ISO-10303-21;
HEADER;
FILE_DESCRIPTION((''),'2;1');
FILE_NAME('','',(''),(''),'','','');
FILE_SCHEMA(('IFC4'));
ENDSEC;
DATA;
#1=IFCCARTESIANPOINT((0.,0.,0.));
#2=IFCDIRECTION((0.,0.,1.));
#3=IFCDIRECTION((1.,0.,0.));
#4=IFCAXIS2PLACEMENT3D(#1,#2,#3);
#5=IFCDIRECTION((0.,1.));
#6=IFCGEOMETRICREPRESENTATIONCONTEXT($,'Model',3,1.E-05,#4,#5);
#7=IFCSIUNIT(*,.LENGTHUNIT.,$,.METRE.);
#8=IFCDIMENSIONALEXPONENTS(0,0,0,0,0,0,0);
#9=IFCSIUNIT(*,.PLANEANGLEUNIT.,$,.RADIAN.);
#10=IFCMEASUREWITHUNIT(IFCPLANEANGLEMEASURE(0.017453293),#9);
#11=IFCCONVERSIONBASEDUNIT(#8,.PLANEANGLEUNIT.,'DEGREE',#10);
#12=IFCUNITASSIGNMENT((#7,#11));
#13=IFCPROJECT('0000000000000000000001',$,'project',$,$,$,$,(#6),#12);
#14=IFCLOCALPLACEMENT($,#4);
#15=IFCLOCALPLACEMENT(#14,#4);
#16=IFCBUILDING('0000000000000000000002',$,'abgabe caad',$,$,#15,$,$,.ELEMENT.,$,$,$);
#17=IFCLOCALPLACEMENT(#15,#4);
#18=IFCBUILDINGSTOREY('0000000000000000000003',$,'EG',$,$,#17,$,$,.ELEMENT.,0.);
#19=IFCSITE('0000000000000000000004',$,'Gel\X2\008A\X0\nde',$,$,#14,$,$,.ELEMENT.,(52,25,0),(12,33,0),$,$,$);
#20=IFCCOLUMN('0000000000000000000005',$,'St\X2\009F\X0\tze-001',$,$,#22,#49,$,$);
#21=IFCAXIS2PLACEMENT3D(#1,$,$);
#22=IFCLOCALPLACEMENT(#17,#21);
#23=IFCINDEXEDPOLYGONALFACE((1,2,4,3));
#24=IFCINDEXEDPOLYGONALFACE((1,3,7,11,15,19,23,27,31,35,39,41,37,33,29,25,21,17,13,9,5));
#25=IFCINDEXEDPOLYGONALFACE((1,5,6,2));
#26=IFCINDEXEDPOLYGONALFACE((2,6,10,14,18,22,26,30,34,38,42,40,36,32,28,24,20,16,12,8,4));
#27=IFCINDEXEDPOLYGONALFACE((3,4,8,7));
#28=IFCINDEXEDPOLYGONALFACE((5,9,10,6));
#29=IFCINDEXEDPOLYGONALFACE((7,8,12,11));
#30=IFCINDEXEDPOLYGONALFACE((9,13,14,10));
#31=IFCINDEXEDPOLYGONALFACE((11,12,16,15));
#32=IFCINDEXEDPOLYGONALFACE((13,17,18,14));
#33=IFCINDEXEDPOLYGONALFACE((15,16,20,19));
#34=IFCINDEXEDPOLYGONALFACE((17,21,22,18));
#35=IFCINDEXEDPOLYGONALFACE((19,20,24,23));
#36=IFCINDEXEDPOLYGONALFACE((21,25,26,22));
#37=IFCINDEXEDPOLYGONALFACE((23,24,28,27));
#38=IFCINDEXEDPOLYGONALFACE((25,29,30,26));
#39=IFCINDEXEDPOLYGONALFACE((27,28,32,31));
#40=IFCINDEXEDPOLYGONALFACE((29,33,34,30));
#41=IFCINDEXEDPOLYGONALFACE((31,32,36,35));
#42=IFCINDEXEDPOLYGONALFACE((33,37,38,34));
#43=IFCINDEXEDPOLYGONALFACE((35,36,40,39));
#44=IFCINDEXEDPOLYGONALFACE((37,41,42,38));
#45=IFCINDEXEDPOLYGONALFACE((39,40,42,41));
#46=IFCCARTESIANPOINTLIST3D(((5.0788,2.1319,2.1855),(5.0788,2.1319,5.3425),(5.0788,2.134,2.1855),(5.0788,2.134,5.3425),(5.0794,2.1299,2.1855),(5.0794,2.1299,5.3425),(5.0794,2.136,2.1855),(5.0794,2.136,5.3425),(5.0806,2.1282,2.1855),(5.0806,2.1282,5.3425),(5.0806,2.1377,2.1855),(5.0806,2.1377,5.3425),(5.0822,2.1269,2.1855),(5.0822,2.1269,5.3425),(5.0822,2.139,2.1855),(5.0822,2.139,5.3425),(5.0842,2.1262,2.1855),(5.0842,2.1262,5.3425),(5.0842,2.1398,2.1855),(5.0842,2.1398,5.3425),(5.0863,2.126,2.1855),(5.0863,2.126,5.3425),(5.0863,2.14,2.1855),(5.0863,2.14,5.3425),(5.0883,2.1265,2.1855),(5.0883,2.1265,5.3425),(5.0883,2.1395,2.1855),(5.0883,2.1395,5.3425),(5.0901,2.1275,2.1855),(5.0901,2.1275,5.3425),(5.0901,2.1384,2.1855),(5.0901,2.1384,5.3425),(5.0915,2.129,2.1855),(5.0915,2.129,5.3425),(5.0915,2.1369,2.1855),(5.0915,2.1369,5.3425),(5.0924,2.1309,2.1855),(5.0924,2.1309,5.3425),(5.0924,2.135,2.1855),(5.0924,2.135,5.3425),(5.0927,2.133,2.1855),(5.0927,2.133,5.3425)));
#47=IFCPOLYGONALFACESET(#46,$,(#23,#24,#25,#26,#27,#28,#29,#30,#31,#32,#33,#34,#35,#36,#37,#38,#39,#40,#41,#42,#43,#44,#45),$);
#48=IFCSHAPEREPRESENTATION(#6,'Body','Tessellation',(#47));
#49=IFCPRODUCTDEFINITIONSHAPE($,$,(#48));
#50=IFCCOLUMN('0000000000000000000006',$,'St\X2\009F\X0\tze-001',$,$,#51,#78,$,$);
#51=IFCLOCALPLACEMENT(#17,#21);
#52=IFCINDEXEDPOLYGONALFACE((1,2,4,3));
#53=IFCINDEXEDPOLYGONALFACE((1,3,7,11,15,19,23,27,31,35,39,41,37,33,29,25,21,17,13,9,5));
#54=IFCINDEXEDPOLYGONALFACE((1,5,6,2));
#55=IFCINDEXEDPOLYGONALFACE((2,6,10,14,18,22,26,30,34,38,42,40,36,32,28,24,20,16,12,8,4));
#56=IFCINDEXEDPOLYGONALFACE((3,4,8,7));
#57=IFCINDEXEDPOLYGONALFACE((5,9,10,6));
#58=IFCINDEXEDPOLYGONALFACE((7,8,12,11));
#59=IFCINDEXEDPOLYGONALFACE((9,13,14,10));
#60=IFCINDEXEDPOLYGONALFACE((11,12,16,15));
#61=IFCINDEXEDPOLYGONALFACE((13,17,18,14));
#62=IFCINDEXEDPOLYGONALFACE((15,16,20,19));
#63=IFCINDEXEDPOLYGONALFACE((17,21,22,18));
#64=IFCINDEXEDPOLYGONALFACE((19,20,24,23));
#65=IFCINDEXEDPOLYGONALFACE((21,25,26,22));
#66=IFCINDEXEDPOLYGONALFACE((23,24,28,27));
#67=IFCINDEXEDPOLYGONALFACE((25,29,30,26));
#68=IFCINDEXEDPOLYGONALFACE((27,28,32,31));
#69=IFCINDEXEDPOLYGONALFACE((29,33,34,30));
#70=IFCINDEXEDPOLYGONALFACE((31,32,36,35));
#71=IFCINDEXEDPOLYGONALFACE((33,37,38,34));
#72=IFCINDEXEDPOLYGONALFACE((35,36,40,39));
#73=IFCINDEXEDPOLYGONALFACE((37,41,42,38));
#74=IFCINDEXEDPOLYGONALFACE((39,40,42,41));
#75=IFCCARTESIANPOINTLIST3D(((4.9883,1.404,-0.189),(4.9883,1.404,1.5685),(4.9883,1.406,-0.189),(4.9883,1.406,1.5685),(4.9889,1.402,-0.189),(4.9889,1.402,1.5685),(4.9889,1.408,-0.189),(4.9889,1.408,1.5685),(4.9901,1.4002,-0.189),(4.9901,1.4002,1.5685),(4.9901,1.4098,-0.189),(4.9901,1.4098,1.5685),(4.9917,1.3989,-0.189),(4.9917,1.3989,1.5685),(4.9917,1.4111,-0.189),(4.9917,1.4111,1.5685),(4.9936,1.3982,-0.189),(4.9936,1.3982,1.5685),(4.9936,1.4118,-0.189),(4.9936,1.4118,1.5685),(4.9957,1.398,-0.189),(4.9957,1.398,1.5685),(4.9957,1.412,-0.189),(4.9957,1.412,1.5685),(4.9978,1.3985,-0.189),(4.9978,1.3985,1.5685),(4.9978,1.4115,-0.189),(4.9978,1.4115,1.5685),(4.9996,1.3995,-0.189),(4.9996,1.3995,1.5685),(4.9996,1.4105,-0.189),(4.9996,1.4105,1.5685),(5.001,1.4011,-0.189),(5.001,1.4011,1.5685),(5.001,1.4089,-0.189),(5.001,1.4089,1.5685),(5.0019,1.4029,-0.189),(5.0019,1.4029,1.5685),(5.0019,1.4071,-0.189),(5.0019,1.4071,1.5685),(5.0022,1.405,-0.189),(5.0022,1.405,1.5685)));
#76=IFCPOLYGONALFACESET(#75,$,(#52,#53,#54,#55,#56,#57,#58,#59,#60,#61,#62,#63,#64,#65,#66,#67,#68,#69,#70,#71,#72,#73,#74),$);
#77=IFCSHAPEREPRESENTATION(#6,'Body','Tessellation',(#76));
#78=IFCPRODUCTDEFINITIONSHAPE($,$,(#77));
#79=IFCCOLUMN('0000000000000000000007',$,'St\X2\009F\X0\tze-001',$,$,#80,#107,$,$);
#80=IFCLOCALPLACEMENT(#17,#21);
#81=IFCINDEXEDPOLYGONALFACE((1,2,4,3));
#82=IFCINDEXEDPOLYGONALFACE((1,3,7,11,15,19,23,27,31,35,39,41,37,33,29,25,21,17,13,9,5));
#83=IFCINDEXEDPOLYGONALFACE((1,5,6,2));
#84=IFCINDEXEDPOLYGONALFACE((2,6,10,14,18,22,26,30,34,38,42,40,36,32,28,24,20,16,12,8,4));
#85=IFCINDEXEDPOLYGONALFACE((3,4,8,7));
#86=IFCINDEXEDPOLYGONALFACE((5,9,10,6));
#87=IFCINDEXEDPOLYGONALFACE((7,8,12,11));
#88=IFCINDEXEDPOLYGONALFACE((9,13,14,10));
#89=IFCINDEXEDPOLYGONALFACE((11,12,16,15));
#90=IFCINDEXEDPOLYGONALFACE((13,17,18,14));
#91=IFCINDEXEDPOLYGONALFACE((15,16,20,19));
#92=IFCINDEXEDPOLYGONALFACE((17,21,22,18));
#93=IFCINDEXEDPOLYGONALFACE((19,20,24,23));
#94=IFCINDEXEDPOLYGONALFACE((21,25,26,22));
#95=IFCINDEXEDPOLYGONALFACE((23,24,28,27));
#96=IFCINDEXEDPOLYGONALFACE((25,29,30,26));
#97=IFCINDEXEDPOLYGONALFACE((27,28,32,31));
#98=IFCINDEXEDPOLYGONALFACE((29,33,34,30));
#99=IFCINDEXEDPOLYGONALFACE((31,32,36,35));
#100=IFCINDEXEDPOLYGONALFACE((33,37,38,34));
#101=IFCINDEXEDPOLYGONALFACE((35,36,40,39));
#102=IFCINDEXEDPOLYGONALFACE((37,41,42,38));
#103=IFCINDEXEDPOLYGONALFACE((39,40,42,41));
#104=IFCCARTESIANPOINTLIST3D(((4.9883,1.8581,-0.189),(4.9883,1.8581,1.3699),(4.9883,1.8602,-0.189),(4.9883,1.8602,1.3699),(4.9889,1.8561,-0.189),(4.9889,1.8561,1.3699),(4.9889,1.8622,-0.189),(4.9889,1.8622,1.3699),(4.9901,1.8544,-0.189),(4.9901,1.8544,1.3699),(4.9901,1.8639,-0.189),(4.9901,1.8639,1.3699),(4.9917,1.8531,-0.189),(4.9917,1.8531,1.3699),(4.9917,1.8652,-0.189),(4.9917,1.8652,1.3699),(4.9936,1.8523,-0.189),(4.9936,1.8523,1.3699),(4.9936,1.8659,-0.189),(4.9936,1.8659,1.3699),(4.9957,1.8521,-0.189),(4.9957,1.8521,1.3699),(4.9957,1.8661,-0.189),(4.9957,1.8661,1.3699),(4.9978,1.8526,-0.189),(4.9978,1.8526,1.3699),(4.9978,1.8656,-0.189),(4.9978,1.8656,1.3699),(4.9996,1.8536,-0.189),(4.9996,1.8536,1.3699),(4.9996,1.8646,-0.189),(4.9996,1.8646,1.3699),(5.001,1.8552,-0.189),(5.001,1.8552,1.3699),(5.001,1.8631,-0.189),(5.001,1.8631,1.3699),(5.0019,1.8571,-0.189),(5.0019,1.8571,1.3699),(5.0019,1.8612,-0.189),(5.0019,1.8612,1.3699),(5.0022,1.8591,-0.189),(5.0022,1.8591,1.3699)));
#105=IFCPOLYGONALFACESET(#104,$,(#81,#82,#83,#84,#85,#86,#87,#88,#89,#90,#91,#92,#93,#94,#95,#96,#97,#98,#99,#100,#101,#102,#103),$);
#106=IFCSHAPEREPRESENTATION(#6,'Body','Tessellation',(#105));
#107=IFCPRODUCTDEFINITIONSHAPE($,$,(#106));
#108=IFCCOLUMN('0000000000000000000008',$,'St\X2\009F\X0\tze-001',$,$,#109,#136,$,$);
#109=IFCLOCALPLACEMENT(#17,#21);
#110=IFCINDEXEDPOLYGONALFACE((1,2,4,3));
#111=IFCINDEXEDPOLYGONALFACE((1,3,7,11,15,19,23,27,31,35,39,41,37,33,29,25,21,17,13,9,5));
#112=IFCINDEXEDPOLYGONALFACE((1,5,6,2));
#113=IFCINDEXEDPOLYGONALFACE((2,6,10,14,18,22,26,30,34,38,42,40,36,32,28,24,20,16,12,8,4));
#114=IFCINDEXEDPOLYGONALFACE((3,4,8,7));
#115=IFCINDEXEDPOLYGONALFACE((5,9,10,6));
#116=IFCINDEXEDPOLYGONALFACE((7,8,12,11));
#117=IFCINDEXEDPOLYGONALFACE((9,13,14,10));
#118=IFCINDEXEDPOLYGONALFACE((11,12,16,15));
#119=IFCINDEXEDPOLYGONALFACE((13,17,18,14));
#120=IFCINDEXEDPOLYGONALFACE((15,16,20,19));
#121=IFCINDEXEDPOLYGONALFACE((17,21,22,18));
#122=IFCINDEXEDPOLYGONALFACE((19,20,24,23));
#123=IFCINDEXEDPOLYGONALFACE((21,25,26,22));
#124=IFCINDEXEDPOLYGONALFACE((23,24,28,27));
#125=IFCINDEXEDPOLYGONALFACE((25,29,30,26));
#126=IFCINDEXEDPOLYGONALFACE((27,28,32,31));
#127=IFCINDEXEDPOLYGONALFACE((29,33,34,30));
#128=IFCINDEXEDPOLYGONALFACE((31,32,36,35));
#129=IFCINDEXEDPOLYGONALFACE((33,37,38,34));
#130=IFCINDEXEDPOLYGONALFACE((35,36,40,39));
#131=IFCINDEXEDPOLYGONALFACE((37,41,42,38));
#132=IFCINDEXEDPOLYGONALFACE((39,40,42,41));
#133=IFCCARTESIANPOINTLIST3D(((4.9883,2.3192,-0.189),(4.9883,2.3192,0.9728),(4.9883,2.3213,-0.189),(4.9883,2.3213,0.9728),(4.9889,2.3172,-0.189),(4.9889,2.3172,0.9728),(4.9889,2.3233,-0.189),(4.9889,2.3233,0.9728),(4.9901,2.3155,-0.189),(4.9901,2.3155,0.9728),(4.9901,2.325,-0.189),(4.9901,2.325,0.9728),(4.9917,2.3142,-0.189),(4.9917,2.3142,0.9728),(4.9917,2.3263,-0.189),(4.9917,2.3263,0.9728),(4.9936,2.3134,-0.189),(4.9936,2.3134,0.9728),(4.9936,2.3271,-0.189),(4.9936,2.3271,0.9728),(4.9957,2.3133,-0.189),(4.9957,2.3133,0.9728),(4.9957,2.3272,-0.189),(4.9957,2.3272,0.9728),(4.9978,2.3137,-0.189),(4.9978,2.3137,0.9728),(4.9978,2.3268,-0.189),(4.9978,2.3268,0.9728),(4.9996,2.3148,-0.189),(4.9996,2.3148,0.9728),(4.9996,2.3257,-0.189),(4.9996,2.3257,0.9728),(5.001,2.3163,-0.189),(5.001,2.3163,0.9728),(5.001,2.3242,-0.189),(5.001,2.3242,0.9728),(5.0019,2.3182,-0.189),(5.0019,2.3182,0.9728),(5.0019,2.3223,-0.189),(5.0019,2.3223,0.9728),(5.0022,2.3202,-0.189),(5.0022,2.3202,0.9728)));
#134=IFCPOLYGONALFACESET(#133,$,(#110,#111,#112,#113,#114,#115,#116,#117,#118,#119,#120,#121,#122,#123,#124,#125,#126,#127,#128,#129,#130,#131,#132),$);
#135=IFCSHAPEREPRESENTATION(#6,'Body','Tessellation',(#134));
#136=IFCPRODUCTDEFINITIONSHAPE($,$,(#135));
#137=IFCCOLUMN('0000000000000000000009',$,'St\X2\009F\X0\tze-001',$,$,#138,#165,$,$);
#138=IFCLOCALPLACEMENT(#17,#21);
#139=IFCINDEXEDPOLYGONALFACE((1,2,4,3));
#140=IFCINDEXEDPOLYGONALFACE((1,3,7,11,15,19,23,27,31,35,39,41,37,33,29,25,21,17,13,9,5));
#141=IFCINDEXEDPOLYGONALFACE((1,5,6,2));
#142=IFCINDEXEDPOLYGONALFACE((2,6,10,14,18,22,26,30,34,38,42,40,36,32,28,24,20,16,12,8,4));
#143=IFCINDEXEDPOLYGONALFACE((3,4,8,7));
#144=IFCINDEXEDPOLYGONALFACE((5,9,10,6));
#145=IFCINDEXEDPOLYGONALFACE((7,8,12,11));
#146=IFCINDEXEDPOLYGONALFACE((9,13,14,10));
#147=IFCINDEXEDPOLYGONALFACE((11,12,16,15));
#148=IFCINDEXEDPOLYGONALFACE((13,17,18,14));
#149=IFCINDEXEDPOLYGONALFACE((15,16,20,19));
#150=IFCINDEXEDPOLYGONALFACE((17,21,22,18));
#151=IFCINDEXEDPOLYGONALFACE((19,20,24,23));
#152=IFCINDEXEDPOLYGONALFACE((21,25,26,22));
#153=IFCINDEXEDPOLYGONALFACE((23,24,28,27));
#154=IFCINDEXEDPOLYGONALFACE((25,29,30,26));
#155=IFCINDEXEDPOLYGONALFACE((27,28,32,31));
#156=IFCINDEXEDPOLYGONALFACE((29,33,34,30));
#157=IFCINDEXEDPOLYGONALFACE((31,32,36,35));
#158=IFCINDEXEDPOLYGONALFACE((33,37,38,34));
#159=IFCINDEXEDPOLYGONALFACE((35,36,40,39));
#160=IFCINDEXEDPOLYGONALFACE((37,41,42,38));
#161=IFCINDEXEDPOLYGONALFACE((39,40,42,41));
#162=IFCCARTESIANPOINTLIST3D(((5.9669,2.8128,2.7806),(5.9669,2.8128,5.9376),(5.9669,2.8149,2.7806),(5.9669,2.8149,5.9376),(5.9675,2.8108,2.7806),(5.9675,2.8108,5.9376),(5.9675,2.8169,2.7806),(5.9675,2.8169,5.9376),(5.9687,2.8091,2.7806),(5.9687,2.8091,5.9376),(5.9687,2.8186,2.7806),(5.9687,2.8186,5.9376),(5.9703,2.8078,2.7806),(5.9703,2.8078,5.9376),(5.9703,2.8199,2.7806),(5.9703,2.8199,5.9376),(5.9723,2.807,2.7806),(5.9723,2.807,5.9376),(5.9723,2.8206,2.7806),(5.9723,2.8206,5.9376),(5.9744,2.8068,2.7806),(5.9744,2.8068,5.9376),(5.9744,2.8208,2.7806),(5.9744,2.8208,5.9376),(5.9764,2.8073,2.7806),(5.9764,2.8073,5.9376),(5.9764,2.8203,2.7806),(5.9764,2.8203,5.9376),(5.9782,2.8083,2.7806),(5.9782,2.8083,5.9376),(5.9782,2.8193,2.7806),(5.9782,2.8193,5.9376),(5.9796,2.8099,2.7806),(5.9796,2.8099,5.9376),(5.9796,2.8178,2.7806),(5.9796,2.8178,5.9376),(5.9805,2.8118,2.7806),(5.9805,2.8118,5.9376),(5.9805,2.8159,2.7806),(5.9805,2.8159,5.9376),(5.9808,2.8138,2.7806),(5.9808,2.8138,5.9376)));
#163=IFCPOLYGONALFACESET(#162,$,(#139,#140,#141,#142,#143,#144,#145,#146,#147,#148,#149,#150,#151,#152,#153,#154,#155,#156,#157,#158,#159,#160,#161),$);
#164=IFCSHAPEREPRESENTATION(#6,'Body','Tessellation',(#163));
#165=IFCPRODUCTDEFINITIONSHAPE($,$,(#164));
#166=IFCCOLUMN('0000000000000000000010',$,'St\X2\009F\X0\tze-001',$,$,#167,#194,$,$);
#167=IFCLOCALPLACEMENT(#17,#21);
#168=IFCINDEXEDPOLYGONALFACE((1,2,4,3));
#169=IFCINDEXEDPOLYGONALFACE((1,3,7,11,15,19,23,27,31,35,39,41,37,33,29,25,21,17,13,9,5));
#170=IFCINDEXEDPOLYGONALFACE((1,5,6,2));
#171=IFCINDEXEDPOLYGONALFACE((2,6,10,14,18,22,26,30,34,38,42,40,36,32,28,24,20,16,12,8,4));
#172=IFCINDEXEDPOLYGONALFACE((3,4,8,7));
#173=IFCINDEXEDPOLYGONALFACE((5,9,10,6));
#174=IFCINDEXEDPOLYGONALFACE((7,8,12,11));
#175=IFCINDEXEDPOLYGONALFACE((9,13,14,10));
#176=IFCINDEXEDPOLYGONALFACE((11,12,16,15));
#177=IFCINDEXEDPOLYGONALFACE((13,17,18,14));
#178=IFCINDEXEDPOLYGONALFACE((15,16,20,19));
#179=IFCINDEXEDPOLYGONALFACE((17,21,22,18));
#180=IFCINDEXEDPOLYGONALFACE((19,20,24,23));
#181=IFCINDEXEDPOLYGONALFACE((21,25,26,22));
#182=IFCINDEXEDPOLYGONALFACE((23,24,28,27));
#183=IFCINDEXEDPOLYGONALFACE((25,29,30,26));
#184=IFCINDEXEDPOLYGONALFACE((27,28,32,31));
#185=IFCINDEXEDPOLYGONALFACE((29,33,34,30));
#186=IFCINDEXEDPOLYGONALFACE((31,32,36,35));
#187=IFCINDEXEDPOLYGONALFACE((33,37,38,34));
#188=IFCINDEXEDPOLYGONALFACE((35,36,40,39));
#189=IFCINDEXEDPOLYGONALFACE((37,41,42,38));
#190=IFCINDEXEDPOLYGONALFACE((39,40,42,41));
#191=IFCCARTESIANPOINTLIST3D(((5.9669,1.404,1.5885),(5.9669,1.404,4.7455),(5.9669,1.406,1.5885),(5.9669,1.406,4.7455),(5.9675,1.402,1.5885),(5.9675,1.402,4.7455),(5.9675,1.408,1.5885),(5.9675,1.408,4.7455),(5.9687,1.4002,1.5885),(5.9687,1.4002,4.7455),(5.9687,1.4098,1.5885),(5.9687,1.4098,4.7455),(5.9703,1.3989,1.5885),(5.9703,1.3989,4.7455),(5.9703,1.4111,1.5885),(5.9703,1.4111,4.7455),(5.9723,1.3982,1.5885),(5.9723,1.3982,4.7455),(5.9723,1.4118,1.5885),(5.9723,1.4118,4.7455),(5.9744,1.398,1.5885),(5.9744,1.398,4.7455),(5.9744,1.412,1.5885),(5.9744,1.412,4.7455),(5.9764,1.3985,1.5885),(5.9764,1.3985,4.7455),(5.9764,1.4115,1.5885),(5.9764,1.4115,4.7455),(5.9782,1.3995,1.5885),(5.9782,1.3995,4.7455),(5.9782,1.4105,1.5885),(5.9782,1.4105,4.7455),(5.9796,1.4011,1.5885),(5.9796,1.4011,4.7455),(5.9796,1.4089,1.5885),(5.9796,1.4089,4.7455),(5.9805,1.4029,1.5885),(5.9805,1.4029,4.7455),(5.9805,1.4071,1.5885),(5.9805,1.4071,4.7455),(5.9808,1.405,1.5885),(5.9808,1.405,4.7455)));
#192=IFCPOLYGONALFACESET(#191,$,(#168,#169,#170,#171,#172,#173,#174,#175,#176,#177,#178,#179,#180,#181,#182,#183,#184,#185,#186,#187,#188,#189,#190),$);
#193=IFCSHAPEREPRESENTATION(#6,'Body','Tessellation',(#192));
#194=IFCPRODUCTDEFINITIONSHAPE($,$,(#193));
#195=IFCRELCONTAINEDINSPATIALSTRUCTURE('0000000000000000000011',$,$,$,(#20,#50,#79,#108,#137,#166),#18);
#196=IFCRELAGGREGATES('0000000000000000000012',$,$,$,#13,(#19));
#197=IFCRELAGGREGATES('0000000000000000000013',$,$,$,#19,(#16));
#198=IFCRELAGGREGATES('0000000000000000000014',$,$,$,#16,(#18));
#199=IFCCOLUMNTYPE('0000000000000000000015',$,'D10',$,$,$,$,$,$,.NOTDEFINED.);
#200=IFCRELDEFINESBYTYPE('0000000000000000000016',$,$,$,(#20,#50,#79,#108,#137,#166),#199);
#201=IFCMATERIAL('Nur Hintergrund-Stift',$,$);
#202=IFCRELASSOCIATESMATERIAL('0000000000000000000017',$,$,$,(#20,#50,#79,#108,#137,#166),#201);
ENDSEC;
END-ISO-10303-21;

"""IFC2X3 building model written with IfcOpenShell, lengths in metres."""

from ifc_helpers import new_model, entity, si_unit, converted_unit, direction, frame, origin_with_axes, origin_2d_with_axis, place, context, project, spatial, circle, extrude, material, type_object, element, save


model = new_model("IFC2X3")

# Units and contexts
model_context = context("Model", 3, precision=1e-05, world=origin_with_axes(), true_north=direction((0.0, 1.0)))
ifc_project = project(units=[si_unit("LENGTHUNIT", "METRE"), converted_unit("PLANEANGLEUNIT", "DEGREE", entity("IfcPlaneAngleMeasure", 0.017453293), si_unit("PLANEANGLEUNIT", "RADIAN"), dimensions=[0, 0, 0, 0, 0, 0, 0])], contexts=[model_context])

# Site, building, storey
site_placement = place(None, origin_with_axes())
site = spatial("IfcSite", under=ifc_project, at=site_placement, Name="Gel\u008ande", CompositionType="ELEMENT", RefLatitude=(52, 25, 0), RefLongitude=(12, 33, 0))
building_placement = place(site_placement, origin_with_axes())
building = spatial("IfcBuilding", under=site, at=building_placement, Name="abgabe caad", CompositionType="ELEMENT")
storey_placement = place(building_placement, origin_with_axes())
storey = spatial("IfcBuildingStorey", under=building, at=storey_placement, Name="EG", CompositionType="ELEMENT", Elevation=0.0)

# Columns
ifc_material_1 = material(Name="Nur Hintergrund-Stift")
column_type = type_object("IfcColumnType", Name="D10", PredefinedType="NOTDEFINED")
for number, where, z_axis, x_axis, name in (
    (1, (5.0857, 2.133, 2.1855), (0.0, 0.0, 1.0), (1.0, 0.0, 0.0), "St\u009ftze-001"),
):
    element("IfcColumn", number, at=place(storey_placement, frame(where, z_axis=z_axis, x_axis=x_axis)), inside=storey, type_object=column_type, material=ifc_material_1, Name=name, context=model_context, shape_type="SweptSolid", body=[
        extrude(circle(Radius=0.007, at=origin_2d_with_axis()), origin_with_axes(), (0.0, 0.0, 1.0), 3.157),
    ])
column_1_placement = place(storey_placement, frame((4.9952, 1.405, -0.189), z_axis=(0.0, 0.0, 1.0), x_axis=(1.0, 0.0, 0.0)))
element("IfcColumn", 2, at=column_1_placement, inside=storey, type_object=column_type, material=ifc_material_1, Name="St\u009ftze-001", context=model_context, shape_type="SweptSolid", body=[
    extrude(circle(Radius=0.007, at=origin_2d_with_axis()), origin_with_axes(), (0.0, 0.0, 1.0), 1.7575),
])
column_2_placement = place(storey_placement, frame((4.9952, 1.8591, -0.189), z_axis=(0.0, 0.0, 1.0), x_axis=(1.0, 0.0, 0.0)))
element("IfcColumn", 3, at=column_2_placement, inside=storey, type_object=column_type, material=ifc_material_1, Name="St\u009ftze-001", context=model_context, shape_type="SweptSolid", body=[
    extrude(circle(Radius=0.007, at=origin_2d_with_axis()), origin_with_axes(), (0.0, 0.0, 1.0), 1.5589),
])
column_3_placement = place(storey_placement, frame((4.9952, 2.3202, -0.189), z_axis=(0.0, 0.0, 1.0), x_axis=(1.0, 0.0, 0.0)))
element("IfcColumn", 4, at=column_3_placement, inside=storey, type_object=column_type, material=ifc_material_1, Name="St\u009ftze-001", context=model_context, shape_type="SweptSolid", body=[
    extrude(circle(Radius=0.007, at=origin_2d_with_axis()), origin_with_axes(), (0.0, 0.0, 1.0), 1.1618),
])
for number, where, z_axis, x_axis, name in (
    (5, (5.9738, 2.8138, 2.7806), (0.0, 0.0, 1.0), (1.0, 0.0, 0.0), "St\u009ftze-001"),
    (6, (5.9738, 1.405, 1.5885), (0.0, 0.0, 1.0), (1.0, 0.0, 0.0), "St\u009ftze-001"),
):
    element("IfcColumn", number, at=place(storey_placement, frame(where, z_axis=z_axis, x_axis=x_axis)), inside=storey, type_object=column_type, material=ifc_material_1, Name=name, context=model_context, shape_type="SweptSolid", body=[
        extrude(circle(Radius=0.007, at=origin_2d_with_axis()), origin_with_axes(), (0.0, 0.0, 1.0), 3.157),
    ])

save(model, "model.ifc")
